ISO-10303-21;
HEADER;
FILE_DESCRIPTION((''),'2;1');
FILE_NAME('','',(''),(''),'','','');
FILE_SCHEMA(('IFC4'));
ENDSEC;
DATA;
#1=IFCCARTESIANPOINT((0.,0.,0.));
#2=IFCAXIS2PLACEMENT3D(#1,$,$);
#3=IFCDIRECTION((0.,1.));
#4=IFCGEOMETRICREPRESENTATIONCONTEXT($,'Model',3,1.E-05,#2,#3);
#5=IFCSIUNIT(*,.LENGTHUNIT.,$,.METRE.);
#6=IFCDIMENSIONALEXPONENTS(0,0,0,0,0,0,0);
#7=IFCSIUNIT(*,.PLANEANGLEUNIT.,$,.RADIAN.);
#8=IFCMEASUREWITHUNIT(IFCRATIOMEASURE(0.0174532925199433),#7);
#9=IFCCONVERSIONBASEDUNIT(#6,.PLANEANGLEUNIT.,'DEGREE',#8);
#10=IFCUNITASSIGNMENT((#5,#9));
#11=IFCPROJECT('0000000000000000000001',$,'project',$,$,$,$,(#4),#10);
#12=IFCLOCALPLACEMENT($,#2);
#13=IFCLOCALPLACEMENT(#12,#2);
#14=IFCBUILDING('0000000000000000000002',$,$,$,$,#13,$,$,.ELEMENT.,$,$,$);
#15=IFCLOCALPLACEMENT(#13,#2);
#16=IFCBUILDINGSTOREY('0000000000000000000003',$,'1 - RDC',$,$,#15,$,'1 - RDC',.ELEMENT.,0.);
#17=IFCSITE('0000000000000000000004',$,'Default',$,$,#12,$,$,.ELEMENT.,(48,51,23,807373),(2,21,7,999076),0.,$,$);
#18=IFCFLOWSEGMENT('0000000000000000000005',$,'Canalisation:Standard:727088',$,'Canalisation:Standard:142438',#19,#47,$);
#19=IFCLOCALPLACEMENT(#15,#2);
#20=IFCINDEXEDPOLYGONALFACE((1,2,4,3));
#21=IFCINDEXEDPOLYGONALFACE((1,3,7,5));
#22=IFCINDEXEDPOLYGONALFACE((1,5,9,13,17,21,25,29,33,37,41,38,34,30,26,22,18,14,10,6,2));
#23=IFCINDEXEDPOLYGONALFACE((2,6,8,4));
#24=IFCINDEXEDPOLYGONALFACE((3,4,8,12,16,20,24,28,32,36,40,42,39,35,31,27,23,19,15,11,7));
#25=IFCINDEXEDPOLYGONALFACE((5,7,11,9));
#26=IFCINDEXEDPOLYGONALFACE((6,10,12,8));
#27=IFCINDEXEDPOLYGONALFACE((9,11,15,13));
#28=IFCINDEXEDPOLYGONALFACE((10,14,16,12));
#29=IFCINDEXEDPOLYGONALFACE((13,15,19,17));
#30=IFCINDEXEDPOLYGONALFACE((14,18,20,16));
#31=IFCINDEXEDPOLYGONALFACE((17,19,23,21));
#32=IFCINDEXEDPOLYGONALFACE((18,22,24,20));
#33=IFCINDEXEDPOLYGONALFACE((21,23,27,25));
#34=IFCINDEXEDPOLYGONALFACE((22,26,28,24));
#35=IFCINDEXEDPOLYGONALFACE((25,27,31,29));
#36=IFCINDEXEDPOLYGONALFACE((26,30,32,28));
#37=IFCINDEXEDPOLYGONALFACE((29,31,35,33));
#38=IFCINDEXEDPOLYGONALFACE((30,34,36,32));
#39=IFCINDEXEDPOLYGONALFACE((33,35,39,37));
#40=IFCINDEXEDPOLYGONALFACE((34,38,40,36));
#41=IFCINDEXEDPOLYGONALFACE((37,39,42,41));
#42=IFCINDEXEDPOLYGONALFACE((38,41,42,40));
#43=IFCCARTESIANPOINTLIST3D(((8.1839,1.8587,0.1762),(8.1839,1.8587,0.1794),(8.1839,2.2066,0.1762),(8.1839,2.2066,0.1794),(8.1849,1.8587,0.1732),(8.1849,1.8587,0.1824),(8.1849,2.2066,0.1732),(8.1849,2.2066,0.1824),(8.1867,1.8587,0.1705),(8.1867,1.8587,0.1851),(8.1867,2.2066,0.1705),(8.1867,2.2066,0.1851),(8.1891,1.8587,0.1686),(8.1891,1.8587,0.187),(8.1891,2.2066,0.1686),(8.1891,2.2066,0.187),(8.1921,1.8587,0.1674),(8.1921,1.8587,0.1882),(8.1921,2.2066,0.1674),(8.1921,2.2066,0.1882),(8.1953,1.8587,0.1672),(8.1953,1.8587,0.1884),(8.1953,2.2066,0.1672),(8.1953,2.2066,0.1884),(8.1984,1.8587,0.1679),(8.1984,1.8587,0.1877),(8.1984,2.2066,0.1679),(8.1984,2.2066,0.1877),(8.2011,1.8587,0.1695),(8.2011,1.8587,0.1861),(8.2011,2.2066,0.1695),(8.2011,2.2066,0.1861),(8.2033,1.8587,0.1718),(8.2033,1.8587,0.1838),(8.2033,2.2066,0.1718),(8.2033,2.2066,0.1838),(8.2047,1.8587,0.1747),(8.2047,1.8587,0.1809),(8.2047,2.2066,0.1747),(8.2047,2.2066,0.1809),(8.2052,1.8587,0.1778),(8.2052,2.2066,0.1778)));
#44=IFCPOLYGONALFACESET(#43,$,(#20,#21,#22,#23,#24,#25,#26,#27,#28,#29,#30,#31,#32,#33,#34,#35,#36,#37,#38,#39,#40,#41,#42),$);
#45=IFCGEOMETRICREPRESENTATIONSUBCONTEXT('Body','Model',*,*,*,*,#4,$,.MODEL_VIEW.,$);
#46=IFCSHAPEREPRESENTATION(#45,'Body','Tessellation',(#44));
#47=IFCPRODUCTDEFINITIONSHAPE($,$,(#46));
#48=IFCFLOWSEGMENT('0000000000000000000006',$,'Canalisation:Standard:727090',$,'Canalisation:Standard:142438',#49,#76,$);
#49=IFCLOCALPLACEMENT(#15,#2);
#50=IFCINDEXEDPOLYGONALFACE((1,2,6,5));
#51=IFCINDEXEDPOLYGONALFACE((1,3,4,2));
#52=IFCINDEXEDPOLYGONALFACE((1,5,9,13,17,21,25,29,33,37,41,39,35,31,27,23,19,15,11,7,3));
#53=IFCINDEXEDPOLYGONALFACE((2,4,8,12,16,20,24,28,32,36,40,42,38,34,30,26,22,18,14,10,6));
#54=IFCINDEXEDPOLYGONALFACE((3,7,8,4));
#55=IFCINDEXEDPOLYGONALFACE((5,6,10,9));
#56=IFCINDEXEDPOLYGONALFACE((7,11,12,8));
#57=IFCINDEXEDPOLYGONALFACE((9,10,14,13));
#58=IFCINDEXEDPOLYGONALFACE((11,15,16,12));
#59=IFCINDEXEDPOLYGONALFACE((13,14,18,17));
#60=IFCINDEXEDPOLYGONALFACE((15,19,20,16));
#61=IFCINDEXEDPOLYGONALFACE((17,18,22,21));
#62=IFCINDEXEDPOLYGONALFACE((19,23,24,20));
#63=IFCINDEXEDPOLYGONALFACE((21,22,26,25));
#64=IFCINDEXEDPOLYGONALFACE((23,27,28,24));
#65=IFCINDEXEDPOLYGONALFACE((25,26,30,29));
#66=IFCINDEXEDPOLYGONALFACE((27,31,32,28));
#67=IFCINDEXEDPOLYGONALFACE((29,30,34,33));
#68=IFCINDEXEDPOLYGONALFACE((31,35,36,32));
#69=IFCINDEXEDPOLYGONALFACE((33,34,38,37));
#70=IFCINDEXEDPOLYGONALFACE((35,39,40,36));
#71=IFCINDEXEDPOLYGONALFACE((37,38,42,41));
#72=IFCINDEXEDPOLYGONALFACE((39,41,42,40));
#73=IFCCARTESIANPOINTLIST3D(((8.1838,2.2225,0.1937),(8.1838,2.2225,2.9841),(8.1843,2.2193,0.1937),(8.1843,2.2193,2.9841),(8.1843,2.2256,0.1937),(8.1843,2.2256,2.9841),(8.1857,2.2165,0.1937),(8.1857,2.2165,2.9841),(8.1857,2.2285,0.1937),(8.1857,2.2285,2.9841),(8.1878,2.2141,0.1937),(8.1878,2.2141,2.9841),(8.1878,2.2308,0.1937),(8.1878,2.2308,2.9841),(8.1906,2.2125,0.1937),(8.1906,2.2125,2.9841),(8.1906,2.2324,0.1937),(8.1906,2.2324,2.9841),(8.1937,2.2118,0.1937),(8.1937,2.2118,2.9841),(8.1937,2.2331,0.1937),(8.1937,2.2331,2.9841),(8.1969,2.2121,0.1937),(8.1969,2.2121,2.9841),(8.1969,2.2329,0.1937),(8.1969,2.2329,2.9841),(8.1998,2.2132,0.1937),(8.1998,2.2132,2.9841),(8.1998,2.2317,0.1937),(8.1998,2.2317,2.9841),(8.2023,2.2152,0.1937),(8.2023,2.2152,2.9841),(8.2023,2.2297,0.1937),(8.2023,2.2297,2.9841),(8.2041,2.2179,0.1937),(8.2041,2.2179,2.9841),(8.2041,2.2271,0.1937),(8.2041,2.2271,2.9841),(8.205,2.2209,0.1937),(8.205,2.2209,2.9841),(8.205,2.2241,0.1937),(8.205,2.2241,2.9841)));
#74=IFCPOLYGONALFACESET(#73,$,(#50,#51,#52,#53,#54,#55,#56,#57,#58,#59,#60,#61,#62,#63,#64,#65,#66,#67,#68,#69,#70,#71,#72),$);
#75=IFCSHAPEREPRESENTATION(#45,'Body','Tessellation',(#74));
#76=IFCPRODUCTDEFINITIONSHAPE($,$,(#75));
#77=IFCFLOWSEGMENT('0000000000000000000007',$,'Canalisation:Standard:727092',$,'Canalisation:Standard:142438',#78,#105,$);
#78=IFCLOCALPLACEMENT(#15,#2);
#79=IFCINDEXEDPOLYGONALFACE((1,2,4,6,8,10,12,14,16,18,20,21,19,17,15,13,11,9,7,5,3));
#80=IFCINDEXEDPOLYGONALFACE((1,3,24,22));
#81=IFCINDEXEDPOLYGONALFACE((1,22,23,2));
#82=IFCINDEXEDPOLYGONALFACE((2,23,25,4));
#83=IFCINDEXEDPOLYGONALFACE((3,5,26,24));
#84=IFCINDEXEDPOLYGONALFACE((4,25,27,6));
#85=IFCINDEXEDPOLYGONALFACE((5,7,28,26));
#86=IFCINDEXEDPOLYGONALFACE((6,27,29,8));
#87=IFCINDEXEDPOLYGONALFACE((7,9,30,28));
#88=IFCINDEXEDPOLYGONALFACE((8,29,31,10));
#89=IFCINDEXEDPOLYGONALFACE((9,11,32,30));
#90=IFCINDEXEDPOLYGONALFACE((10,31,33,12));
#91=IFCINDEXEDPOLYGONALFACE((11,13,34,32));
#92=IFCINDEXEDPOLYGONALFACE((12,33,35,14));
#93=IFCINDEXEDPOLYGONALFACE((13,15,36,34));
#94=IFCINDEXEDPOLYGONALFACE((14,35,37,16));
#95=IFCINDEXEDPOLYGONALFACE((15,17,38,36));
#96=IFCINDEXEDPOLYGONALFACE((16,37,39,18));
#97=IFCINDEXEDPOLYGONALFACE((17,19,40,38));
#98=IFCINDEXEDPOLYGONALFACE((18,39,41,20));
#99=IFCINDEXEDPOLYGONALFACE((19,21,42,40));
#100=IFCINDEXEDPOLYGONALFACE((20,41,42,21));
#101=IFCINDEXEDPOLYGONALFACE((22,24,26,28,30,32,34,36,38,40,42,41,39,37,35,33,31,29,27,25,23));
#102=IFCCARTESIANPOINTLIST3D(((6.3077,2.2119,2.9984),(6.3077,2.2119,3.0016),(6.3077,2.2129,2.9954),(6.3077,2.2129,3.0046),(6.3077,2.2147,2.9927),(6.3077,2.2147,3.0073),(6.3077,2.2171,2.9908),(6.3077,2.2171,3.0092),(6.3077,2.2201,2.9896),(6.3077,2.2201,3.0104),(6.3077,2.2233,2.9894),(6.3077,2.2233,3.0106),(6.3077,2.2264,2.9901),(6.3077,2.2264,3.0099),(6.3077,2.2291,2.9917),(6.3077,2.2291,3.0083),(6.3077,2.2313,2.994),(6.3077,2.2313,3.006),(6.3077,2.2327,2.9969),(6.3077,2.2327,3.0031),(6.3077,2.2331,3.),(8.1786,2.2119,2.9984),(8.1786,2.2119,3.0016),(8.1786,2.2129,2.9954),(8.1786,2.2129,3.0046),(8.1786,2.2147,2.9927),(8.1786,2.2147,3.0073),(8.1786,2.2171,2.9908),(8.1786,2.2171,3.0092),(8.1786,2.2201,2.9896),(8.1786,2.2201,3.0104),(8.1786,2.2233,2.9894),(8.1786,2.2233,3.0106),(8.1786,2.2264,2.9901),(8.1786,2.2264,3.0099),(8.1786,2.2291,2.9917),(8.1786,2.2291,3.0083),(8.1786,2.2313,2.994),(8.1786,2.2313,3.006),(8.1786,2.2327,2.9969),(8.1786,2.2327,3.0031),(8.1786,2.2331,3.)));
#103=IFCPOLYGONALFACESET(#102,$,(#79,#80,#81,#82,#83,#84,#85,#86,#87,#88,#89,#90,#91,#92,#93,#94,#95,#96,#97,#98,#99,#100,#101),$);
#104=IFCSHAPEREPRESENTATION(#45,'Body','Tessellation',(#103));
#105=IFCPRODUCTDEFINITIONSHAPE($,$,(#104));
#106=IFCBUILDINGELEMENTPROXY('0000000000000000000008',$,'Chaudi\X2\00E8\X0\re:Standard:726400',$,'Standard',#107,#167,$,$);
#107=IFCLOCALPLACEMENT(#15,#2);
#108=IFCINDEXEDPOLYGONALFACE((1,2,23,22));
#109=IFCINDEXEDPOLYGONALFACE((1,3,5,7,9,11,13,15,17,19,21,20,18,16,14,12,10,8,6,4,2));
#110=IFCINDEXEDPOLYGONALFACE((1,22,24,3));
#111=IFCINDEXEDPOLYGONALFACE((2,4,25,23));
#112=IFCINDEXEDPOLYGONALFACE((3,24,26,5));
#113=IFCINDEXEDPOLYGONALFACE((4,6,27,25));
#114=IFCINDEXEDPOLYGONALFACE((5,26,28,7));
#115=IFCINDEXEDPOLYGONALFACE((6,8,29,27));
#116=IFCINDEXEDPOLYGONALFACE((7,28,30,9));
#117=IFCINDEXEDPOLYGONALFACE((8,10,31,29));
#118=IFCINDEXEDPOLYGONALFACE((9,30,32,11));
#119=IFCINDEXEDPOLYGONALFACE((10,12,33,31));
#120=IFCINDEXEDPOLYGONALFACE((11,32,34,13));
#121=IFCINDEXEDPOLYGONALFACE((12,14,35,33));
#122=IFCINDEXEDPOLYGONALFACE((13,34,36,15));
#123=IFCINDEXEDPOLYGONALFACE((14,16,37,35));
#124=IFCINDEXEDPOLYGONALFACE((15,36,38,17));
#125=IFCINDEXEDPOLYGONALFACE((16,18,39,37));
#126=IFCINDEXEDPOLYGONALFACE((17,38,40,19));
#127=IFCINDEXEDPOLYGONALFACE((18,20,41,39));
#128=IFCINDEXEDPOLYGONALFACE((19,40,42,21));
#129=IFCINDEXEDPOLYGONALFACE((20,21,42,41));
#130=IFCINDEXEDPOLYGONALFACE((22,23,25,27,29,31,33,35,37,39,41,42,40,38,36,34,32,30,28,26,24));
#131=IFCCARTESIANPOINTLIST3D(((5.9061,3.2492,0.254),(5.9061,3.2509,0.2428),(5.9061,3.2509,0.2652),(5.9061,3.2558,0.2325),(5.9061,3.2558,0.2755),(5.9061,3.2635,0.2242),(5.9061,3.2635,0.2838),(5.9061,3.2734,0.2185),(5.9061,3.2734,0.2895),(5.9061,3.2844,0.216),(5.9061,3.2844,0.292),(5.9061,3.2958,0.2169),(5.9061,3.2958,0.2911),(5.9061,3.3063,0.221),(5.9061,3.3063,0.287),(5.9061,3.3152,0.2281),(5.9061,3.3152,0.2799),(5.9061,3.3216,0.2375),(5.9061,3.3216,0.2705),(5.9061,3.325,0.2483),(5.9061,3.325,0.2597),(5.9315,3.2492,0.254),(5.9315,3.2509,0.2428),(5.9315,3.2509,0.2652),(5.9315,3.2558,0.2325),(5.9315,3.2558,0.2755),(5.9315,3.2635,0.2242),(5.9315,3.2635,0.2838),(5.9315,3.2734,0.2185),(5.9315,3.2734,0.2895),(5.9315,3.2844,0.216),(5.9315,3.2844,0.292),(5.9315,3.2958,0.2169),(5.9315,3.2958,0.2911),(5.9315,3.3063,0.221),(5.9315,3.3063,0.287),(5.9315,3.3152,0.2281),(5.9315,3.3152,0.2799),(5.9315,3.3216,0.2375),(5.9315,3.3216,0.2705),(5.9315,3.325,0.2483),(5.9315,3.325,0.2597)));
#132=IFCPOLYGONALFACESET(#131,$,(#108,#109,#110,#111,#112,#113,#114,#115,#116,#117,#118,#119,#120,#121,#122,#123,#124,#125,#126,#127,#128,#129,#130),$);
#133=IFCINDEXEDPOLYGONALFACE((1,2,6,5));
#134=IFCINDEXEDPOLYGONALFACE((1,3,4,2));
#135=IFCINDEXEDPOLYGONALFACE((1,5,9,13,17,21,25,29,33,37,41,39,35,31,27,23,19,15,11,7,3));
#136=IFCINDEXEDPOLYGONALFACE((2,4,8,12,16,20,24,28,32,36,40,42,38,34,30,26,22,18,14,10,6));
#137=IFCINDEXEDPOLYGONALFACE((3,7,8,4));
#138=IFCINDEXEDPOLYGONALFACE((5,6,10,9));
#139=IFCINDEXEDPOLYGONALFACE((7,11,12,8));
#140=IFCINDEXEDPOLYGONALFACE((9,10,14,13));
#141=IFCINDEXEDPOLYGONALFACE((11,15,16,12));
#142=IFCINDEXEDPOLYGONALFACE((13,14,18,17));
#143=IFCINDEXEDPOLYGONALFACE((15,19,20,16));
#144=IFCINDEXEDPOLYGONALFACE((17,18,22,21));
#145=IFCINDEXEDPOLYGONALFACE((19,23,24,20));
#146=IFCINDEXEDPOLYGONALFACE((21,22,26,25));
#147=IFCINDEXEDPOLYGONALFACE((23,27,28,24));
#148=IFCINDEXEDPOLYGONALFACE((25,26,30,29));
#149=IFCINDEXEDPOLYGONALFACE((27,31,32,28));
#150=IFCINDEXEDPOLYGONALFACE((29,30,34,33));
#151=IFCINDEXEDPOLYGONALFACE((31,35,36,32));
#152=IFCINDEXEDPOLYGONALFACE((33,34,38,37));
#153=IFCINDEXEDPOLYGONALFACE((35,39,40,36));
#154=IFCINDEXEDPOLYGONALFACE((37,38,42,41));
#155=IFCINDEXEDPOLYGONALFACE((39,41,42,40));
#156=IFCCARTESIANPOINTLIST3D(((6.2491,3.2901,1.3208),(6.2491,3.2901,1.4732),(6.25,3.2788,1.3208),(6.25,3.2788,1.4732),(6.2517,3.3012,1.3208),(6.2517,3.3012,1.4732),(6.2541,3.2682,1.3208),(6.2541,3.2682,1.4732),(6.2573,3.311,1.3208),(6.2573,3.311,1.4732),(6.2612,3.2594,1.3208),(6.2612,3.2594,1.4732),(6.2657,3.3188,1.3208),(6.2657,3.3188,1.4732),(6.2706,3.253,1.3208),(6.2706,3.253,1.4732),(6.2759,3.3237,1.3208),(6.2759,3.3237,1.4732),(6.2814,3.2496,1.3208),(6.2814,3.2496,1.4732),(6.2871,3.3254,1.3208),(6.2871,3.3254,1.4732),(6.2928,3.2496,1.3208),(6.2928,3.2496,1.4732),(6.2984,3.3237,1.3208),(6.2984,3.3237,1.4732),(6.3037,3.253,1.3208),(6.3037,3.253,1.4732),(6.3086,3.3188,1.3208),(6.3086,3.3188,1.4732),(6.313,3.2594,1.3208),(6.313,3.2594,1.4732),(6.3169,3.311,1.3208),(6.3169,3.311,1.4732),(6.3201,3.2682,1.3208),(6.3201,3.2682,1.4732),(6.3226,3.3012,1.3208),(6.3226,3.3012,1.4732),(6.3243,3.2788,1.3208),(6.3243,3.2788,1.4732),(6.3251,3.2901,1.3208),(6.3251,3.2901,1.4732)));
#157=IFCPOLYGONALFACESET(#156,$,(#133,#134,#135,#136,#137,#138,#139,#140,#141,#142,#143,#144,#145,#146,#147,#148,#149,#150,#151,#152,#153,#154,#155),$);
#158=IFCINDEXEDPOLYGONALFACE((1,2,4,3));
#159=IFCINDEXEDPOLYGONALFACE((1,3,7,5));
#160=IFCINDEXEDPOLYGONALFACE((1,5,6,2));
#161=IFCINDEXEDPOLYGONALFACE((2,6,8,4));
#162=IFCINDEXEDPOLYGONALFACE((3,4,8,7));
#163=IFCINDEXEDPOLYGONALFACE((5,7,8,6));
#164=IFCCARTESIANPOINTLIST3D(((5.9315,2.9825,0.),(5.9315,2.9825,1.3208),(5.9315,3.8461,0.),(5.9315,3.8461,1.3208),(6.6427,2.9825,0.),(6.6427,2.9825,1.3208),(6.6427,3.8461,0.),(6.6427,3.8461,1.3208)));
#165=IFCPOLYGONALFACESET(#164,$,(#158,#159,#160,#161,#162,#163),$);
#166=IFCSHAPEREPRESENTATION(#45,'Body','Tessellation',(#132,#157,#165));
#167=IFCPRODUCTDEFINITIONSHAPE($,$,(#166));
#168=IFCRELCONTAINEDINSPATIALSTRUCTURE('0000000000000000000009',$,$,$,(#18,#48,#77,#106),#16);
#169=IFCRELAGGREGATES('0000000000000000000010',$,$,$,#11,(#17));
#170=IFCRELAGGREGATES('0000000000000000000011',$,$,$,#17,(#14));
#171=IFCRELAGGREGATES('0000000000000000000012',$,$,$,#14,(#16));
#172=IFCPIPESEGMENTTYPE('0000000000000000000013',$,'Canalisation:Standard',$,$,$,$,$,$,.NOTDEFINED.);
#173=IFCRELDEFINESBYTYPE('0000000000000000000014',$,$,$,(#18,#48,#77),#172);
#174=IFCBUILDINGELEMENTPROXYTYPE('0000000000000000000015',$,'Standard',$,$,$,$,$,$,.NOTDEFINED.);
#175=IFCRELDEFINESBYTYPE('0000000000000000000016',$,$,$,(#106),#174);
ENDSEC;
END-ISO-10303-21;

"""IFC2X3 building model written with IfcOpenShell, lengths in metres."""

from ifc_helpers import new_model, entity, si_unit, converted_unit, direction, frame, frame_2d, origin, origin_2d_with_axis, place, context, subcontext, project, spatial, rectangle, circle, extrude, source, transform, mapped, type_object, type_shapes, element, save


model = new_model("IFC2X3")

# Units and contexts
model_context = context("Model", 3, precision=1e-05, world=origin(), true_north=direction((0.0, 1.0)))
body_context = subcontext(model_context, "Body", "Model", "MODEL_VIEW")
ifc_project = project(units=[si_unit("LENGTHUNIT", "METRE"), converted_unit("PLANEANGLEUNIT", "DEGREE", entity("IfcRatioMeasure", 0.0174532925199433), si_unit("PLANEANGLEUNIT", "RADIAN"), dimensions=[0, 0, 0, 0, 0, 0, 0])], contexts=[model_context])

# Site, building, storey
site_placement = place(None, origin())
site = spatial("IfcSite", under=ifc_project, at=site_placement, Name="Default", CompositionType="ELEMENT", RefLatitude=(48, 51, 23, 807373), RefLongitude=(2, 21, 7, 999076), RefElevation=0.0)
building_placement = place(site_placement, origin())
building = spatial("IfcBuilding", under=site, at=building_placement, CompositionType="ELEMENT")
storey_placement = place(building_placement, origin())
storey = spatial("IfcBuildingStorey", under=building, at=storey_placement, Name="1 - RDC", LongName="1 - RDC", CompositionType="ELEMENT", Elevation=0.0)

# Flow segments
pipe_segment_type = type_object("IfcPipeSegmentType", Name="Canalisation:Standard", PredefinedType="NOTDEFINED")
flow_segment_1_placement = place(storey_placement, origin())
element("IfcFlowSegment", 1, at=flow_segment_1_placement, inside=storey, type_object=pipe_segment_type, Name="Canalisation:Standard:727088", ObjectType="Canalisation:Standard:142438", context=body_context, shape_type="SweptSolid", body=[
    extrude(circle(Radius=0.0107, at=origin_2d_with_axis()), frame((8.1945, 1.8587, 0.1778), z_axis=(0.0, 1.0, 0.0), x_axis=(1.0, 0.0, 0.0)), (0.0, 0.0, 1.0), 0.3479),
])
flow_segment_2_placement = place(storey_placement, origin())
element("IfcFlowSegment", 2, at=flow_segment_2_placement, inside=storey, type_object=pipe_segment_type, Name="Canalisation:Standard:727090", ObjectType="Canalisation:Standard:142438", context=body_context, shape_type="SweptSolid", body=[
    extrude(circle(Radius=0.0107, at=origin_2d_with_axis()), frame((8.1945, 2.2225, 0.1937), z_axis=(0.0, 0.0, 1.0), x_axis=(-1.0, 0.0, 0.0)), (0.0, 0.0, 1.0), 2.7904),
])
flow_segment_3_placement = place(storey_placement, origin())
element("IfcFlowSegment", 3, at=flow_segment_3_placement, inside=storey, type_object=pipe_segment_type, Name="Canalisation:Standard:727092", ObjectType="Canalisation:Standard:142438", context=body_context, shape_type="SweptSolid", body=[
    extrude(circle(Radius=0.0107, at=frame_2d((0.0, 0.0), x_axis=(1.0, 0.0))), frame((6.3077, 2.2225, 3.0), z_axis=(1.0, 0.0, 0.0), x_axis=(0.0, 1.0, 0.0)), (0.0, 0.0, 1.0), 1.8709),
])

# Building element proxy
building_element_proxy_type_1 = type_object("IfcBuildingElementProxyType", Name="Standard", PredefinedType="NOTDEFINED")
shared_shape_1 = source(origin(), body_context, "Body", "SweptSolid", [
    extrude(circle(Radius=0.0381, at=frame_2d((0.0, 0.0), x_axis=(1.0, 0.0))), frame((0.3048, 0.7112, 0.254), z_axis=(0.0, 1.0, 0.0), x_axis=(-1.0, 0.0, 0.0)), (0.0, 0.0, 1.0), 0.0254),
    extrude(circle(Radius=0.0381, at=frame_2d((0.0, 0.0), x_axis=(1.0, 0.0))), frame((0.3048, 0.3556, 1.3208)), (0.0, 0.0, 1.0), 0.1524),
    extrude(rectangle(XDim=0.7112, YDim=0.8636, at=frame_2d((0.0, 0.0), x_axis=(1.0, 0.0))), frame((0.4318, 0.3556, 0.0), z_axis=(0.0, 0.0, 1.0), x_axis=(0.0, 1.0, 0.0)), (0.0, 0.0, 1.0), 1.3208),
])
type_shapes(building_element_proxy_type_1, [shared_shape_1])
proxy_1_placement = place(storey_placement, frame((6.6427, 2.9825, 0.0), z_axis=(0.0, 0.0, 1.0), x_axis=(0.0, 1.0, 0.0)))
element("IfcBuildingElementProxy", 4, at=proxy_1_placement, inside=storey, type_object=building_element_proxy_type_1, Name="Chaudière:Standard:726400", ObjectType="Standard", context=body_context, shape_type="MappedRepresentation", body=[
    mapped(shared_shape_1, transform((0.0, 0.0, 0.0), scale=1.0)),
])

save(model, "model.ifc")
